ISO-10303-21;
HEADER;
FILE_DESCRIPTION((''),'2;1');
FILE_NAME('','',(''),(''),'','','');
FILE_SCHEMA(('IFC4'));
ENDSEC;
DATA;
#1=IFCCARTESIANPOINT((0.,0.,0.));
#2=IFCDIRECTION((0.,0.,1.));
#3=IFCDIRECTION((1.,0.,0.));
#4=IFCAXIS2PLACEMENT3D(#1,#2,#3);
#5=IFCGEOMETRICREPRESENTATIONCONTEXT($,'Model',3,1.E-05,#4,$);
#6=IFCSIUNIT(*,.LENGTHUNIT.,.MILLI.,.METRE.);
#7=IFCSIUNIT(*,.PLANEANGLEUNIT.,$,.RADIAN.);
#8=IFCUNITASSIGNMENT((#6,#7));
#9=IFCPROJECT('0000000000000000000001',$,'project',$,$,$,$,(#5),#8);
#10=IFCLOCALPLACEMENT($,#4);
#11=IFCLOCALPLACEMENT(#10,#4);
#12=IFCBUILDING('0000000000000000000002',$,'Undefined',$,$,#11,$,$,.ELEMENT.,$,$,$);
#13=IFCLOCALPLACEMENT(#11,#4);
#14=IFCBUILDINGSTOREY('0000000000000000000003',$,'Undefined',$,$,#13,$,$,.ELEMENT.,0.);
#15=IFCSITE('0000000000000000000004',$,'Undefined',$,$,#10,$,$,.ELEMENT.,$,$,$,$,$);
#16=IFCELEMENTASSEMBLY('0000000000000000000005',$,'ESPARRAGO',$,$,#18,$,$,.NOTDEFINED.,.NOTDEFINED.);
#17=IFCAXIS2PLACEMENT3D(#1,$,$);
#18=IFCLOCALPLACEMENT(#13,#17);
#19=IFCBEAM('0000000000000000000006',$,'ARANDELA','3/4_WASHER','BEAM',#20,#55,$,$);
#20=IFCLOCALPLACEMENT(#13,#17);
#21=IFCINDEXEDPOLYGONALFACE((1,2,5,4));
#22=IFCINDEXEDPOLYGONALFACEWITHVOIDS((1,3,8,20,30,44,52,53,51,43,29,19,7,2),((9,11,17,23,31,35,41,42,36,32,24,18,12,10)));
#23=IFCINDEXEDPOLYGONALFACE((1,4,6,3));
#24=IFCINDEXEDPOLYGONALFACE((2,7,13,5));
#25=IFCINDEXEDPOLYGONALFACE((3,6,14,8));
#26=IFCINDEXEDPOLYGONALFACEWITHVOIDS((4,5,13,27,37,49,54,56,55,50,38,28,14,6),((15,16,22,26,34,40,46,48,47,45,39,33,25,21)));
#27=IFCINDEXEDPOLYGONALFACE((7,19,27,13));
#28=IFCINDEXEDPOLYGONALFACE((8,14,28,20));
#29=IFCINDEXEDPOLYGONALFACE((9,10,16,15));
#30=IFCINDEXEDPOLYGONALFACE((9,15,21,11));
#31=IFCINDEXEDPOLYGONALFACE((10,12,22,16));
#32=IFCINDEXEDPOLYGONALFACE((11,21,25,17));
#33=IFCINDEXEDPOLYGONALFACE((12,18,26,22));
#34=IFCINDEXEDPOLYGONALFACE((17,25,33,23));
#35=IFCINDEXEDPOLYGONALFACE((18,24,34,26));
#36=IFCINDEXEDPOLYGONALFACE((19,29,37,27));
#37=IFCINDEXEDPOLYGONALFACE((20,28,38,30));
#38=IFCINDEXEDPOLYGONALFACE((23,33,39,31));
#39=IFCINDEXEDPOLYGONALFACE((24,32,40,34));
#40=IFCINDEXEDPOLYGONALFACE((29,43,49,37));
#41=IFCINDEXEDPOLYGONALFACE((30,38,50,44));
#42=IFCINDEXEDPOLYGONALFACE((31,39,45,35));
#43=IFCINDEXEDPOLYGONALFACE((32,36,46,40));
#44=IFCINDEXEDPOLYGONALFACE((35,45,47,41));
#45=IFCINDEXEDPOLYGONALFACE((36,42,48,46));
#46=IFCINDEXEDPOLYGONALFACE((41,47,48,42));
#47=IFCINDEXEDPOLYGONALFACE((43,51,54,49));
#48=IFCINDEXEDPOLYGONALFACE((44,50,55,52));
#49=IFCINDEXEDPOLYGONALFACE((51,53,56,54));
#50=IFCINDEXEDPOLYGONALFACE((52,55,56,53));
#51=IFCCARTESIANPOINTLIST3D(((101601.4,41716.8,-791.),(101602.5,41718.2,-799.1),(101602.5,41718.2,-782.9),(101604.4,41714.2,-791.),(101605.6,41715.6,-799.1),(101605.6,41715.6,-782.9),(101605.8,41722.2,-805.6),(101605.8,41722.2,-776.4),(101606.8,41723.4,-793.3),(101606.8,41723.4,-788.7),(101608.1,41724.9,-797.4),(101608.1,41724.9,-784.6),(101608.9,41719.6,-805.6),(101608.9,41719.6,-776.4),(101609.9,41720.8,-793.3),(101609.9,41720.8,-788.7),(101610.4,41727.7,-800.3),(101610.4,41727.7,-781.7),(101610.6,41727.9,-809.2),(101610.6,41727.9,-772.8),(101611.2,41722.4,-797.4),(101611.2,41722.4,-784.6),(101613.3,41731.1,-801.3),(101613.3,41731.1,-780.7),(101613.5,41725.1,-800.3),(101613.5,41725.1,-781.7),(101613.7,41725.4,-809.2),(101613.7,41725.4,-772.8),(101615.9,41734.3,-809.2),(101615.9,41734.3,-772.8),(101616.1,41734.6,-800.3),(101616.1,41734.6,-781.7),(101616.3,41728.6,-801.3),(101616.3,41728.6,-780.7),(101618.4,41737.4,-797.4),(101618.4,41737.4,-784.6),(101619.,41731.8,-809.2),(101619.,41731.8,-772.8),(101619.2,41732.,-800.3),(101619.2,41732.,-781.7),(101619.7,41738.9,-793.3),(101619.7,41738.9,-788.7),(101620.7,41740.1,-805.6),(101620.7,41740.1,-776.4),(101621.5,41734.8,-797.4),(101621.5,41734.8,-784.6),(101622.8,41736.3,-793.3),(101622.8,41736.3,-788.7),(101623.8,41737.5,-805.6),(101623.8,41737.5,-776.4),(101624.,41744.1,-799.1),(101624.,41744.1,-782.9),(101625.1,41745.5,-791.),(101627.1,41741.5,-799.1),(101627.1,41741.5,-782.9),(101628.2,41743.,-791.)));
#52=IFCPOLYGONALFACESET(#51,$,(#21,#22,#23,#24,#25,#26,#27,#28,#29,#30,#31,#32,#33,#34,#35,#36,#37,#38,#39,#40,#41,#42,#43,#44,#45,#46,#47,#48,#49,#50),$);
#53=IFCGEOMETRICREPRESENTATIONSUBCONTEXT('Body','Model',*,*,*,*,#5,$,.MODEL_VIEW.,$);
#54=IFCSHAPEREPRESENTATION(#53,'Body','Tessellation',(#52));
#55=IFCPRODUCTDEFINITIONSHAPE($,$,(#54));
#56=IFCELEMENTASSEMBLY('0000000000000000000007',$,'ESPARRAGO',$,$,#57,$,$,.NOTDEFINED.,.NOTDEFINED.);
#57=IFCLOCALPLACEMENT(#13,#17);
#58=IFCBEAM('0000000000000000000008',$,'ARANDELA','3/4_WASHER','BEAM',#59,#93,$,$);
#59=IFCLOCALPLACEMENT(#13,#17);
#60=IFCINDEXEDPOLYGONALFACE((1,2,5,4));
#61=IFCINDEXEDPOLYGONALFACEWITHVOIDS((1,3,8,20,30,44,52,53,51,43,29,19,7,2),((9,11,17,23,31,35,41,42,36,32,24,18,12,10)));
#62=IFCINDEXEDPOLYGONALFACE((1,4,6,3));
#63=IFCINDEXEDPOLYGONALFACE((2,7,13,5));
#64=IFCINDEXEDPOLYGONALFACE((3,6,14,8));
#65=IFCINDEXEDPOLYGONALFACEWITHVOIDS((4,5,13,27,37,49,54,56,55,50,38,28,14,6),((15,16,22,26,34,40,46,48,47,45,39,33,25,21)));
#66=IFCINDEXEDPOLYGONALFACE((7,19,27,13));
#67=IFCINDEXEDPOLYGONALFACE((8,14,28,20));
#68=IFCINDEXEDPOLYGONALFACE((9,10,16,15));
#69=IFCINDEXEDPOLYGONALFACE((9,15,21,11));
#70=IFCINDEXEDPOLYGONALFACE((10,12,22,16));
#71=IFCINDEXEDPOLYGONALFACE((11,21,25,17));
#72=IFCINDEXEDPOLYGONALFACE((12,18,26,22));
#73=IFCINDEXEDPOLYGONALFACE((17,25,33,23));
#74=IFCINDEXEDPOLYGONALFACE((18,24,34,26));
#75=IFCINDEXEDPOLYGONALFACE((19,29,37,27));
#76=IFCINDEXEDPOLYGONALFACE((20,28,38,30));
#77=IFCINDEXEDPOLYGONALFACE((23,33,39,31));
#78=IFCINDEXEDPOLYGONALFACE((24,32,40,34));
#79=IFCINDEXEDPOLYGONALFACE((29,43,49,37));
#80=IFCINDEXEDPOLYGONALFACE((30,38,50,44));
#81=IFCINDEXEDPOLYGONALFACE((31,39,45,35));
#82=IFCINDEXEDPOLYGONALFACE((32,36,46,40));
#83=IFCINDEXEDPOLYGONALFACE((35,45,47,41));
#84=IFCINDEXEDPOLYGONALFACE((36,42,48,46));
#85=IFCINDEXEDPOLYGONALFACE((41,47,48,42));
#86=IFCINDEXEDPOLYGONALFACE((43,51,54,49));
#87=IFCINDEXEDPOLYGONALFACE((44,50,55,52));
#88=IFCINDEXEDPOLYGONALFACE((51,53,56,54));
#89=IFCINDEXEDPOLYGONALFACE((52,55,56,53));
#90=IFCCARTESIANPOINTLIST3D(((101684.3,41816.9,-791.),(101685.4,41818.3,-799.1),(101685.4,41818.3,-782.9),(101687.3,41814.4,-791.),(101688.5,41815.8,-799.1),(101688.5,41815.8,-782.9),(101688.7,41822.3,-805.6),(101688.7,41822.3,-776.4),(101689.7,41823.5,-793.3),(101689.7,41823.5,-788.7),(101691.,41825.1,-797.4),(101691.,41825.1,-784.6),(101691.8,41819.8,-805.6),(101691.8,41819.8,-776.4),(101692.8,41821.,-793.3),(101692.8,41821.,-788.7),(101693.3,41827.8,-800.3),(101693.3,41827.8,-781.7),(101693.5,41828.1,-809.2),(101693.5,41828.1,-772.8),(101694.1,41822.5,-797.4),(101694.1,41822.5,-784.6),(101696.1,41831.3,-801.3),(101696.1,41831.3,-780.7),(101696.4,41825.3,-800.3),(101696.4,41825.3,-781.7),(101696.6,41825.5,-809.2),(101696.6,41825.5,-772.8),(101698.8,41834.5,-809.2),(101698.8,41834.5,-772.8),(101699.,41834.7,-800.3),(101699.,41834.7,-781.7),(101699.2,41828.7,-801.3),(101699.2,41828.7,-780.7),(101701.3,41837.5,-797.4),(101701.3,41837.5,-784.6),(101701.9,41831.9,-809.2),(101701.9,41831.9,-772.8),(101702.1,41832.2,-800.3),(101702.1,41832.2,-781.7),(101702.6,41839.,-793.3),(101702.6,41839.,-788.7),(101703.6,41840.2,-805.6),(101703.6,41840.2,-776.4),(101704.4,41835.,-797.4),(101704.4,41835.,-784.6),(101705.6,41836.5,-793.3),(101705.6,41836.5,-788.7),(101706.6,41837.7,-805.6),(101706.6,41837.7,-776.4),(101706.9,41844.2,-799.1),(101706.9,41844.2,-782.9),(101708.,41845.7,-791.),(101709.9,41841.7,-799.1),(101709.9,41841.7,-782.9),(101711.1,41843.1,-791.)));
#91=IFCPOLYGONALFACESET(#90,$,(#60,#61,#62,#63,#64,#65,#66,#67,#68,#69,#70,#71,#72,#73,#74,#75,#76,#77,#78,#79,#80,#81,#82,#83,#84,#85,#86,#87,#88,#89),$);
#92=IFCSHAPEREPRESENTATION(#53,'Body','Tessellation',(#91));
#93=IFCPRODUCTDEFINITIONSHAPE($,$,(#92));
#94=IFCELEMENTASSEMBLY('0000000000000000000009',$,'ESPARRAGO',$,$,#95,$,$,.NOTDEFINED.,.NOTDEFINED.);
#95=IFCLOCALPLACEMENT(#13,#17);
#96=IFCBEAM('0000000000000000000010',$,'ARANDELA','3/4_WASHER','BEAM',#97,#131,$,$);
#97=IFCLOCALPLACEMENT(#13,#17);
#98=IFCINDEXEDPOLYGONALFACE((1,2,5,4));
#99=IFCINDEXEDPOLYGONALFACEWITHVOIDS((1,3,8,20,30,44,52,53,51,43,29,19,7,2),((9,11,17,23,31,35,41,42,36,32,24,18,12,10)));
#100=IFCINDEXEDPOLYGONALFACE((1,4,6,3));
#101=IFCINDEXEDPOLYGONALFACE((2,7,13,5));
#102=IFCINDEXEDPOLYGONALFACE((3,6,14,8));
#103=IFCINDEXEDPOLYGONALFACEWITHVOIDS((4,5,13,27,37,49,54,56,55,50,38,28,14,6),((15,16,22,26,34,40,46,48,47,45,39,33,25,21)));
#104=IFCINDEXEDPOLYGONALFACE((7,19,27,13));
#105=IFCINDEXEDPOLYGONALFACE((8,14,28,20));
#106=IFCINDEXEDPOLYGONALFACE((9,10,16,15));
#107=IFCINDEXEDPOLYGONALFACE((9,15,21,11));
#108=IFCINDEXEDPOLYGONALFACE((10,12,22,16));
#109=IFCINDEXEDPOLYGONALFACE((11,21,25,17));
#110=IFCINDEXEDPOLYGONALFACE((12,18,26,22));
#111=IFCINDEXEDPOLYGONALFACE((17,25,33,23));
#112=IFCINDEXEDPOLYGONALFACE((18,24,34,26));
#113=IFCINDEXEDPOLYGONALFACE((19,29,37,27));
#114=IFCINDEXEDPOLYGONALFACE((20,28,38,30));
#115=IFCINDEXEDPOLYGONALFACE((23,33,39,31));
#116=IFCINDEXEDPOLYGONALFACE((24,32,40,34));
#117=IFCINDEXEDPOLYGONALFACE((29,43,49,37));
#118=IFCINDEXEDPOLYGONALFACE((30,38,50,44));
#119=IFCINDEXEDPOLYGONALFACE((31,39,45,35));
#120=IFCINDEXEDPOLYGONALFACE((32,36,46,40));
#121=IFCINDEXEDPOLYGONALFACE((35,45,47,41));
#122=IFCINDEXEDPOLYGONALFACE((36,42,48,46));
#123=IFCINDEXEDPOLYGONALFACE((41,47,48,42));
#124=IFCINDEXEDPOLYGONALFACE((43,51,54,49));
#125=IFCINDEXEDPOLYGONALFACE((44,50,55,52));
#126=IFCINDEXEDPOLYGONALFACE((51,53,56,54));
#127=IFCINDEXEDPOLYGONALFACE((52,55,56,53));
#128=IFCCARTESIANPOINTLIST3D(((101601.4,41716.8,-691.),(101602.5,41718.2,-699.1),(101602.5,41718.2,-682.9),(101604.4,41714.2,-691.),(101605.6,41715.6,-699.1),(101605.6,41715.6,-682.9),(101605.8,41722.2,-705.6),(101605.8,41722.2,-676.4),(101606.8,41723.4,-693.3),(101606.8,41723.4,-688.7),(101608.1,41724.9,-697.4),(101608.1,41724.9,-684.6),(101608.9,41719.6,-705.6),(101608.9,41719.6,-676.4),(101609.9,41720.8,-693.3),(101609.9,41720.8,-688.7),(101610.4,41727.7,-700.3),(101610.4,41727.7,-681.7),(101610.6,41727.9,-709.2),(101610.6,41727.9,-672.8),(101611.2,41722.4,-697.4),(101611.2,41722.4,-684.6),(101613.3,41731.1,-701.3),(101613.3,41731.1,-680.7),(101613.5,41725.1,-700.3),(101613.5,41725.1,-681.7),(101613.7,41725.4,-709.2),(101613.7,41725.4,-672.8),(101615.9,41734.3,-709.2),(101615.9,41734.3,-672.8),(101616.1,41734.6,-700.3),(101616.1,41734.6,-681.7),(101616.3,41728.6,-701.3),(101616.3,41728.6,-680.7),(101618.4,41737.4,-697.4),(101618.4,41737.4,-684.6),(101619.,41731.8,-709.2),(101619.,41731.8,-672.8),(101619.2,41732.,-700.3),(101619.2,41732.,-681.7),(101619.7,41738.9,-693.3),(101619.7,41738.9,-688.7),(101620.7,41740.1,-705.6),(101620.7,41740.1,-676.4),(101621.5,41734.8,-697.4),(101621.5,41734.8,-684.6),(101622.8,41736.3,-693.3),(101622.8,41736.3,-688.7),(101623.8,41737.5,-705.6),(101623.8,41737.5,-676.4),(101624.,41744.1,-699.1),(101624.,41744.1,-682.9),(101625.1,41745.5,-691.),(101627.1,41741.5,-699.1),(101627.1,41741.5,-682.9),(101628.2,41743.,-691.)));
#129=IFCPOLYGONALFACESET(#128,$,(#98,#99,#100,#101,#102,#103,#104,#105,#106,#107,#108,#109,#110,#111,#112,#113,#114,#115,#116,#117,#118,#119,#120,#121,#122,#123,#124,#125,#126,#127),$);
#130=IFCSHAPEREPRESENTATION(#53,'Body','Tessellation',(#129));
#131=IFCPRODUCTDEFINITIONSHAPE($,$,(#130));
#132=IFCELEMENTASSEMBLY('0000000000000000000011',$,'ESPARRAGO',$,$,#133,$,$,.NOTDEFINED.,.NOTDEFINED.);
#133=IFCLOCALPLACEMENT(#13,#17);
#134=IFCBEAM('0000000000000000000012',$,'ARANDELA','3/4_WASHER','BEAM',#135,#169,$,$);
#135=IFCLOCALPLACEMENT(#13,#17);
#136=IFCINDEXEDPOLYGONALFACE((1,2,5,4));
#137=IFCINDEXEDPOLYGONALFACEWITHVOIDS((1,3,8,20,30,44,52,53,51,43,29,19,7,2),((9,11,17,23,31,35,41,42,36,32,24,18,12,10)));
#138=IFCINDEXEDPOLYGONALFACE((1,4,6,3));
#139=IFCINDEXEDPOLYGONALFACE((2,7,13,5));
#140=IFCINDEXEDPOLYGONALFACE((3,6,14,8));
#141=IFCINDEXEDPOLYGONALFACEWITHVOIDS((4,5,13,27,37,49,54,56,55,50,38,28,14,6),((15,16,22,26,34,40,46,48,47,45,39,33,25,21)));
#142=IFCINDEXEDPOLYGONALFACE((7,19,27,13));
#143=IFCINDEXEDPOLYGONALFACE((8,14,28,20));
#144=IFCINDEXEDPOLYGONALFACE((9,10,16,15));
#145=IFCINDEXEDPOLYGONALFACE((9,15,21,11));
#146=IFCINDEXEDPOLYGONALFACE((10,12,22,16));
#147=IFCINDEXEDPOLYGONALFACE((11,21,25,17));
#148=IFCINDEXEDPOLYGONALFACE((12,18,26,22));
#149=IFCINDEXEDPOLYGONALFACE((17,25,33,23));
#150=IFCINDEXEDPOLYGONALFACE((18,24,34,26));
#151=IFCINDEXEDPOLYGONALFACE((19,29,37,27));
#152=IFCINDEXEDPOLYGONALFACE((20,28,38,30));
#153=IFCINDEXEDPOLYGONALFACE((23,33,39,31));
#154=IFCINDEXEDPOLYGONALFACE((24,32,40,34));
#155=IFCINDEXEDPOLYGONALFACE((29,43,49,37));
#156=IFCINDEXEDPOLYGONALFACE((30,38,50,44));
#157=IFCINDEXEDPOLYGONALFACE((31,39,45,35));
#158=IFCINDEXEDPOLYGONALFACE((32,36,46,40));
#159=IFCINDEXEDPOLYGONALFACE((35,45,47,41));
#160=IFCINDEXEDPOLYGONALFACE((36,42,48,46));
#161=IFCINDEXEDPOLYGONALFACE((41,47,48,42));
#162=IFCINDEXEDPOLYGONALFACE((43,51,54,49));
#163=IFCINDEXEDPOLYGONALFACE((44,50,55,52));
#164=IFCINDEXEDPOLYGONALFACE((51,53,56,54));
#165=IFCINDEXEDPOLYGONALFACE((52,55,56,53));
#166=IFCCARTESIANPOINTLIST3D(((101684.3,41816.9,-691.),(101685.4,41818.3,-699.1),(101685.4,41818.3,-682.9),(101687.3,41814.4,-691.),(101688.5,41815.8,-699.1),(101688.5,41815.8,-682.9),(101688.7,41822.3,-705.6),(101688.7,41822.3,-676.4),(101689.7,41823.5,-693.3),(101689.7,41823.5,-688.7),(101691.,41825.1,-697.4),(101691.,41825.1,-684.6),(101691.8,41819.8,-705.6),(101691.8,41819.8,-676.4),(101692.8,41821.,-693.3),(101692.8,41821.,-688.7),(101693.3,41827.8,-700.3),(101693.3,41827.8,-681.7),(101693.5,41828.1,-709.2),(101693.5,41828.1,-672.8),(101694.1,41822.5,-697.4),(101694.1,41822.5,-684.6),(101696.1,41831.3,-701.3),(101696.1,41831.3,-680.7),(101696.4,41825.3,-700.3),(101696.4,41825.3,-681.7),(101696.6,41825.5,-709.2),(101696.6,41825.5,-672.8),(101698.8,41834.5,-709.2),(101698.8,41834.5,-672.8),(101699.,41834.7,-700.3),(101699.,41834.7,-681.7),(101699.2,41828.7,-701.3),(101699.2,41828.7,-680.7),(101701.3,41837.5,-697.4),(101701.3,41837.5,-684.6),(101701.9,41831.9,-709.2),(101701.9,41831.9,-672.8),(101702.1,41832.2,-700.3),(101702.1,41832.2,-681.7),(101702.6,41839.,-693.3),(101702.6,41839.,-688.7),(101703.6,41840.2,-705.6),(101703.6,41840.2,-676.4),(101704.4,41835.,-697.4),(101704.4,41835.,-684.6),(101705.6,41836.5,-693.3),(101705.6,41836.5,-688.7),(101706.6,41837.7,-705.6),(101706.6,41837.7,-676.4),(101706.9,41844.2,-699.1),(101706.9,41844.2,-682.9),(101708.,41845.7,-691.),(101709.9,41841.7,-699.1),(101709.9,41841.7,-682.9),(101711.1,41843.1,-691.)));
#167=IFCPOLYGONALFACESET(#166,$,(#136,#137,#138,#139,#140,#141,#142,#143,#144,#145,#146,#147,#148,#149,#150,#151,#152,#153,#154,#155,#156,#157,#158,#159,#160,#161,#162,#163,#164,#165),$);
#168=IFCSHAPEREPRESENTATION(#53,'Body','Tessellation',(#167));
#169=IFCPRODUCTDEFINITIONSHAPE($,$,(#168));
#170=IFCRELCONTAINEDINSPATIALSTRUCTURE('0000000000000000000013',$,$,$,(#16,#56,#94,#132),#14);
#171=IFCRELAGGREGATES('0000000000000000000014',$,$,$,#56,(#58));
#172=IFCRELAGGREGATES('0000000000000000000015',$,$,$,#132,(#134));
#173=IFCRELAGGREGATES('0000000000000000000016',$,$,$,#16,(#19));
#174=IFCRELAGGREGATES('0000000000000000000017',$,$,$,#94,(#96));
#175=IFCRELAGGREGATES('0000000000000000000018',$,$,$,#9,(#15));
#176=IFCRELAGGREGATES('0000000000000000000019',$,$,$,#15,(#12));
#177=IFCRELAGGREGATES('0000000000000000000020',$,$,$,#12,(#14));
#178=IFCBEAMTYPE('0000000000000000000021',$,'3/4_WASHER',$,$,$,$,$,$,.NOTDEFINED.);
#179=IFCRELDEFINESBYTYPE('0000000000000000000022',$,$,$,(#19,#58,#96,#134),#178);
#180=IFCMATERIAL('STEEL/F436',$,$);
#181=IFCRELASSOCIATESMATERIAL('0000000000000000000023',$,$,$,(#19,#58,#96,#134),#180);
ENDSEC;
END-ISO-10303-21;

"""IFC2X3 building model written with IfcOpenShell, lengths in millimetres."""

from ifc_helpers import new_model, si_unit, frame, origin_with_axes, place, context, subcontext, project, spatial, polyline, outline, extrude, material, type_object, element, aggregate, save


model = new_model("IFC2X3")

# Units and contexts
model_context = context("Model", 3, precision=1e-05, world=origin_with_axes())
body_context = subcontext(model_context, "Body", "Model", "MODEL_VIEW")
ifc_project = project(units=[si_unit("LENGTHUNIT", "METRE", prefix="MILLI"), si_unit("PLANEANGLEUNIT", "RADIAN")], contexts=[model_context])

# Site, building, storey
site_placement = place(None, origin_with_axes())
site = spatial("IfcSite", under=ifc_project, at=site_placement, Name="Undefined", CompositionType="ELEMENT")
building_placement = place(site_placement, origin_with_axes())
building = spatial("IfcBuilding", under=site, at=building_placement, Name="Undefined", CompositionType="ELEMENT")
storey_placement = place(building_placement, origin_with_axes())
storey = spatial("IfcBuildingStorey", under=building, at=storey_placement, Name="Undefined", CompositionType="ELEMENT", Elevation=0.0)

# Element assemblies, beams
assembly_1_placement = place(storey_placement, origin_with_axes())
assembly_1 = element("IfcElementAssembly", 1, at=assembly_1_placement, inside=storey, Name="ESPARRAGO", AssemblyPlace="NOTDEFINED", PredefinedType="NOTDEFINED")
ifc_material_1 = material(Name="STEEL/F436")
beam_type_1 = type_object("IfcBeamType", Name="3/4_WASHER", PredefinedType="NOTDEFINED")
beam_1_placement = place(assembly_1_placement, frame((101613.3, 41731.1, -791.0), z_axis=(0.000066, -0.000055, 1.0), x_axis=(0.7704, -0.637561, -0.000086)))
beam_1 = element("IfcBeam", 2, at=beam_1_placement, type_object=beam_type_1, material=ifc_material_1, Name="ARANDELA", Description="3/4_WASHER", ObjectType="BEAM", context=body_context, shape_type="SweptSolid", body=[
    extrude(outline(polyline([(-11.6, -14.6), (-16.8, -8.1), (-18.6, 0.0), (-16.8, 8.1), (-11.6, 14.6), (-4.2, 18.2), (4.2, 18.2), (11.6, 14.6), (16.8, 8.1), (18.6, 0.0), (16.8, -8.1), (11.6, -14.6), (4.2, -18.2), (-4.2, -18.2), (-11.6, -14.6)]), holes=[polyline([(-4.5, 9.3), (-8.1, 6.4), (-10.1, 2.3), (-10.1, -2.3), (-8.1, -6.4), (-4.5, -9.3), (0.0, -10.3), (4.5, -9.3), (8.1, -6.4), (10.1, -2.3), (10.1, 2.3), (8.1, 6.4), (4.5, 9.3), (0.0, 10.3), (-4.5, 9.3)])]), frame((4.0, 0.0, 0.0), z_axis=(-1.0, 0.0, 0.0), x_axis=(0.0, -1.0, 0.0)), (0.0, 0.0, 1.0), 4.0),
])
assembly_2_placement = place(storey_placement, origin_with_axes())
assembly_2 = element("IfcElementAssembly", 3, at=assembly_2_placement, inside=storey, Name="ESPARRAGO", AssemblyPlace="NOTDEFINED", PredefinedType="NOTDEFINED")
beam_2_placement = place(assembly_2_placement, frame((101696.1, 41831.3, -791.0), z_axis=(0.000066, -0.000055, 1.0), x_axis=(0.7704, -0.637561, -0.000086)))
beam_2 = element("IfcBeam", 4, at=beam_2_placement, type_object=beam_type_1, material=ifc_material_1, Name="ARANDELA", Description="3/4_WASHER", ObjectType="BEAM", context=body_context, shape_type="SweptSolid", body=[
    extrude(outline(polyline([(-11.6, -14.6), (-16.8, -8.1), (-18.6, 0.0), (-16.8, 8.1), (-11.6, 14.6), (-4.2, 18.2), (4.2, 18.2), (11.6, 14.6), (16.8, 8.1), (18.6, 0.0), (16.8, -8.1), (11.6, -14.6), (4.2, -18.2), (-4.2, -18.2), (-11.6, -14.6)]), holes=[polyline([(-4.5, 9.3), (-8.1, 6.4), (-10.1, 2.3), (-10.1, -2.3), (-8.1, -6.4), (-4.5, -9.3), (0.0, -10.3), (4.5, -9.3), (8.1, -6.4), (10.1, -2.3), (10.1, 2.3), (8.1, 6.4), (4.5, 9.3), (0.0, 10.3), (-4.5, 9.3)])]), frame((4.0, 0.0, 0.0), z_axis=(-1.0, 0.0, 0.0), x_axis=(0.0, -1.0, 0.0)), (0.0, 0.0, 1.0), 4.0),
])
aggregate(assembly_2, [beam_2])
assembly_3_placement = place(storey_placement, origin_with_axes())
assembly_3 = element("IfcElementAssembly", 5, at=assembly_3_placement, inside=storey, Name="ESPARRAGO", AssemblyPlace="NOTDEFINED", PredefinedType="NOTDEFINED")
beam_3_placement = place(assembly_3_placement, frame((101613.3, 41731.1, -691.0), z_axis=(0.000066, -0.000055, 1.0), x_axis=(0.7704, -0.637561, -0.000086)))
beam_3 = element("IfcBeam", 6, at=beam_3_placement, type_object=beam_type_1, material=ifc_material_1, Name="ARANDELA", Description="3/4_WASHER", ObjectType="BEAM", context=body_context, shape_type="SweptSolid", body=[
    extrude(outline(polyline([(-11.6, -14.6), (-16.8, -8.1), (-18.6, 0.0), (-16.8, 8.1), (-11.6, 14.6), (-4.2, 18.2), (4.2, 18.2), (11.6, 14.6), (16.8, 8.1), (18.6, 0.0), (16.8, -8.1), (11.6, -14.6), (4.2, -18.2), (-4.2, -18.2), (-11.6, -14.6)]), holes=[polyline([(-4.5, 9.3), (-8.1, 6.4), (-10.1, 2.3), (-10.1, -2.3), (-8.1, -6.4), (-4.5, -9.3), (0.0, -10.3), (4.5, -9.3), (8.1, -6.4), (10.1, -2.3), (10.1, 2.3), (8.1, 6.4), (4.5, 9.3), (0.0, 10.3), (-4.5, 9.3)])]), frame((4.0, 0.0, 0.0), z_axis=(-1.0, 0.0, 0.0), x_axis=(0.0, -1.0, 0.0)), (0.0, 0.0, 1.0), 4.0),
])
assembly_4_placement = place(storey_placement, origin_with_axes())
assembly_4 = element("IfcElementAssembly", 7, at=assembly_4_placement, inside=storey, Name="ESPARRAGO", AssemblyPlace="NOTDEFINED", PredefinedType="NOTDEFINED")
beam_4_placement = place(assembly_4_placement, frame((101696.1, 41831.3, -691.0), z_axis=(0.000066, -0.000055, 1.0), x_axis=(0.7704, -0.637561, -0.000086)))
beam_4 = element("IfcBeam", 8, at=beam_4_placement, type_object=beam_type_1, material=ifc_material_1, Name="ARANDELA", Description="3/4_WASHER", ObjectType="BEAM", context=body_context, shape_type="SweptSolid", body=[
    extrude(outline(polyline([(-11.6, -14.6), (-16.8, -8.1), (-18.6, 0.0), (-16.8, 8.1), (-11.6, 14.6), (-4.2, 18.2), (4.2, 18.2), (11.6, 14.6), (16.8, 8.1), (18.6, 0.0), (16.8, -8.1), (11.6, -14.6), (4.2, -18.2), (-4.2, -18.2), (-11.6, -14.6)]), holes=[polyline([(-4.5, 9.3), (-8.1, 6.4), (-10.1, 2.3), (-10.1, -2.3), (-8.1, -6.4), (-4.5, -9.3), (0.0, -10.3), (4.5, -9.3), (8.1, -6.4), (10.1, -2.3), (10.1, 2.3), (8.1, 6.4), (4.5, 9.3), (0.0, 10.3), (-4.5, 9.3)])]), frame((4.0, 0.0, 0.0), z_axis=(-1.0, 0.0, 0.0), x_axis=(0.0, -1.0, 0.0)), (0.0, 0.0, 1.0), 4.0),
])
aggregate(assembly_4, [beam_4])

aggregate(assembly_1, [beam_1])
aggregate(assembly_3, [beam_3])

save(model, "model.ifc")
